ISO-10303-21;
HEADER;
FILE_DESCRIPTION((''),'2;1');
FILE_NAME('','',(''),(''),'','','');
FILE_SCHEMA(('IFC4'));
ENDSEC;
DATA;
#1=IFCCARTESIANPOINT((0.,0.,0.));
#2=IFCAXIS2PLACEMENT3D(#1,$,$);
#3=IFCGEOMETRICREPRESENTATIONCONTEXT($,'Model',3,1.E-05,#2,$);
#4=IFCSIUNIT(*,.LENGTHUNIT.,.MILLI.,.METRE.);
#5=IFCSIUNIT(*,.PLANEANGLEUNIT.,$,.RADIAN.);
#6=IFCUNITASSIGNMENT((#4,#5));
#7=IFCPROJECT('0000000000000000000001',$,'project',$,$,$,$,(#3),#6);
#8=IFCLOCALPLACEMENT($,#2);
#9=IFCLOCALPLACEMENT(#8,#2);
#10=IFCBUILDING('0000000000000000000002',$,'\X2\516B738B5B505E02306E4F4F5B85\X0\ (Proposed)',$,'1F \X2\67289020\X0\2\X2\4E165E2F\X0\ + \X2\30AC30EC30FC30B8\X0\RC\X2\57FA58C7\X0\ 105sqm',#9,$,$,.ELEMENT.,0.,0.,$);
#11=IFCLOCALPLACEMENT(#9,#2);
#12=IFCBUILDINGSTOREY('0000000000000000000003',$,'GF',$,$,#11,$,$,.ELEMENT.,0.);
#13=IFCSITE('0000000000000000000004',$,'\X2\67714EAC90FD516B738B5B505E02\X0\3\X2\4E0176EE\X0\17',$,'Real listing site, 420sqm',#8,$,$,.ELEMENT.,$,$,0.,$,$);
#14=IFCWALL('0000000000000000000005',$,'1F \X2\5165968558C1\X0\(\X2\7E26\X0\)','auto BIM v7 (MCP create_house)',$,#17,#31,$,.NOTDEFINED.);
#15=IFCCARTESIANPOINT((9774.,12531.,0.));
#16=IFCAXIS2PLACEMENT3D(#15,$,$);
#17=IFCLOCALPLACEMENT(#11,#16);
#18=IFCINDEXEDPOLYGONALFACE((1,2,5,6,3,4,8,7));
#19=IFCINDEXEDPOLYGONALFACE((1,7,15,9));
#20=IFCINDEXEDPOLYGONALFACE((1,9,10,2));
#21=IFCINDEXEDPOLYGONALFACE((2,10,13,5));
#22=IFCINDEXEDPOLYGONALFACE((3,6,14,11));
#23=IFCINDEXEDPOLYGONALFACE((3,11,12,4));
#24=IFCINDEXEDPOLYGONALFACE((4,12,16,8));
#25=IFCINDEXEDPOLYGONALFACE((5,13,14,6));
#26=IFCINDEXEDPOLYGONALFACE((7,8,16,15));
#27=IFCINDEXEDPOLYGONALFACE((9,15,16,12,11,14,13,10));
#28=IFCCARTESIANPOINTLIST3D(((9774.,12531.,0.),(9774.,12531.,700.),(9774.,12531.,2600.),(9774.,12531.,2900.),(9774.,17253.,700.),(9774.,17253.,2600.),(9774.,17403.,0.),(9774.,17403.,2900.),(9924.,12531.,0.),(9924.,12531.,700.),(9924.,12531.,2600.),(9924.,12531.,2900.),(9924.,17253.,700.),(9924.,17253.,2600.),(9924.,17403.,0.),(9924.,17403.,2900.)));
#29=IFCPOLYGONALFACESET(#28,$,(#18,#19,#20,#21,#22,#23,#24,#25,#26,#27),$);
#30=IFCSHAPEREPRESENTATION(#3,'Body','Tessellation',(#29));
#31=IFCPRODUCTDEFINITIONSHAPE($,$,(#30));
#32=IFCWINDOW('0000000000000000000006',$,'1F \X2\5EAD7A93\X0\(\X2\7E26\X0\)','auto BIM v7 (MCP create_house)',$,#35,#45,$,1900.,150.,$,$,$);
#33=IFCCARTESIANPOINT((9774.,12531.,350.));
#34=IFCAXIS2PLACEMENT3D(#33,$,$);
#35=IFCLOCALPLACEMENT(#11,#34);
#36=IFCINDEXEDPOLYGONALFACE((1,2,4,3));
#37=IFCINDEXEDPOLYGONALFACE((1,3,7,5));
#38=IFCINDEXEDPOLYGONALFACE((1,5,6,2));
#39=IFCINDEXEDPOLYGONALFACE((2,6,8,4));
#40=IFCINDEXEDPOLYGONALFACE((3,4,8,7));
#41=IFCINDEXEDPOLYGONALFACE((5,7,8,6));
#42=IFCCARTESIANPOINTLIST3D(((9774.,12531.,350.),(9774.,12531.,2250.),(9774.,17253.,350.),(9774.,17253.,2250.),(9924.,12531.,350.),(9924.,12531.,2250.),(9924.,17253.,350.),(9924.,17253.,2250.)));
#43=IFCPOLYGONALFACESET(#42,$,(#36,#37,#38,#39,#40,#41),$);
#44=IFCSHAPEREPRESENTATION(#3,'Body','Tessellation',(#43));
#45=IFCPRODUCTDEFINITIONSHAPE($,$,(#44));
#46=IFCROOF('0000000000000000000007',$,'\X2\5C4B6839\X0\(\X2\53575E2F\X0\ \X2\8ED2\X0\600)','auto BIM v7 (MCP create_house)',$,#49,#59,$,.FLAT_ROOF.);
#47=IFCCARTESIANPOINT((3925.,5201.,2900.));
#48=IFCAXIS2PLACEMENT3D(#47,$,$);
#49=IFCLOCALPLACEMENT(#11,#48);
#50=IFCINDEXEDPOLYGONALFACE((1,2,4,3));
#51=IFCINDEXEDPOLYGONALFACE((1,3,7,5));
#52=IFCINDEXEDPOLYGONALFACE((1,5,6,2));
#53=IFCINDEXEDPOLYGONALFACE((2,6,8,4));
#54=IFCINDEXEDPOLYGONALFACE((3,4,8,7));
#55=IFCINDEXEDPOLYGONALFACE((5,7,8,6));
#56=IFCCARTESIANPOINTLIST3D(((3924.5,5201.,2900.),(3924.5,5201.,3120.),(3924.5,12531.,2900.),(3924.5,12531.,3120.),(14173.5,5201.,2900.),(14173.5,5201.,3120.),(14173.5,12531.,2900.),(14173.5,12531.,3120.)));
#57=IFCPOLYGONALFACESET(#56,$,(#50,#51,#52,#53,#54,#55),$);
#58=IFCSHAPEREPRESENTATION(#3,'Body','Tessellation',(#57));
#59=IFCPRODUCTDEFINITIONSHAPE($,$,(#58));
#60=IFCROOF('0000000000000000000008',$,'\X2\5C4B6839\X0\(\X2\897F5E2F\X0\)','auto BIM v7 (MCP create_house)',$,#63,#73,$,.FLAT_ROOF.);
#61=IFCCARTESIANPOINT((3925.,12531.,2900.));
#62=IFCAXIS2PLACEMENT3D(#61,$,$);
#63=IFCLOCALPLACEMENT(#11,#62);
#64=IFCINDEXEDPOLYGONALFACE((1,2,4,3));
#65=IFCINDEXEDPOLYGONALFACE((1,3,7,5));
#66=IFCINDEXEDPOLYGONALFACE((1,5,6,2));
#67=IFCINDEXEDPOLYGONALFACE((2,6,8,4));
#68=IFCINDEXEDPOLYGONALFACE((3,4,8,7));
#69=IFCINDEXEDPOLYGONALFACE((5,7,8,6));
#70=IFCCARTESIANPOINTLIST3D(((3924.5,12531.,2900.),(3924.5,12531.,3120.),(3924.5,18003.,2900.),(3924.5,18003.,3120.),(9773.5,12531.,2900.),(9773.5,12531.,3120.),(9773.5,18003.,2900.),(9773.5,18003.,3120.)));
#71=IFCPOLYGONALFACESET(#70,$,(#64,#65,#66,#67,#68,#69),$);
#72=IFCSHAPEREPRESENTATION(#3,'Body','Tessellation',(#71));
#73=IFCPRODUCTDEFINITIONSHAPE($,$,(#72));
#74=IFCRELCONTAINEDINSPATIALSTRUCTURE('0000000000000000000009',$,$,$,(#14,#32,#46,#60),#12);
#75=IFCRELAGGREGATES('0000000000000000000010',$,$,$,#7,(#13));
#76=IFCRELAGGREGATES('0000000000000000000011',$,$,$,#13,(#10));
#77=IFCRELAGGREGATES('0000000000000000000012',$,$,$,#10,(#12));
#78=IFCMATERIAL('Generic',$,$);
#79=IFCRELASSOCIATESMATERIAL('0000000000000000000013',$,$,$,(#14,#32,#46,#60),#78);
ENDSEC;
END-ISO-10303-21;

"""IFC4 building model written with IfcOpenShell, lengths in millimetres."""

from ifc_helpers import new_model, si_unit, frame, frame_2d, origin, place, context, project, spatial, rectangle, extrude, material, element, fill, save


model = new_model("IFC4")

# Units and contexts
model_context = context("Model", 3, precision=1e-05, world=origin())
ifc_project = project(units=[si_unit("LENGTHUNIT", "METRE", prefix="MILLI"), si_unit("PLANEANGLEUNIT", "RADIAN")], contexts=[model_context])

# Site, building, storey
site_placement = place(None, origin())
site = spatial("IfcSite", under=ifc_project, at=site_placement, Name="東京都八王子市3丁目17", ObjectType="Real listing site, 420sqm", CompositionType="ELEMENT", RefElevation=0.0)
building_placement = place(site_placement, origin())
building = spatial("IfcBuilding", under=site, at=building_placement, Name="八王子市の住宅 (Proposed)", ObjectType="1F 木造2世帯 + ガレージRC基壇 105sqm", CompositionType="ELEMENT", ElevationOfRefHeight=0.0, ElevationOfTerrain=0.0)
storey_placement = place(building_placement, origin())
storey = spatial("IfcBuildingStorey", under=building, at=storey_placement, Name="GF", CompositionType="ELEMENT", Elevation=0.0)

# Shared definitions
ifc_material = material(Name="Generic")

# Wall, opening, window
wall_1_placement = place(storey_placement, frame((9774.0, 12531.0, 0.0)))
wall_1 = element("IfcWall", 1, at=wall_1_placement, inside=storey, material=ifc_material, Name="1F 入隅壁(縦)", Description="auto BIM v7 (MCP create_house)", PredefinedType="NOTDEFINED", context=model_context, shape_type="SweptSolid", body=[
    extrude(rectangle(XDim=150.0, YDim=4872.0, at=frame_2d((75.0, 2436.0))), frame((9774.0, 12531.0, 0.0)), (0.0, 0.0, 1.0), 2900.0),
])
opening_1_placement = place(storey_placement, frame((9774.0, 12531.0, 350.0)))
opening_1 = element("IfcOpeningElement", 2, at=opening_1_placement, cuts=wall_1, PredefinedType="NOTDEFINED", context=model_context, shape_type="SweptSolid", body=[
    extrude(rectangle(XDim=150.0, YDim=4722.0, at=frame_2d((75.0, 2361.0))), frame((9774.0, 12531.0, 350.0)), (0.0, 0.0, 1.0), 1900.0),
])
window_1_placement = place(storey_placement, frame((9774.0, 12531.0, 350.0)))
window_1 = element("IfcWindow", 3, at=window_1_placement, inside=storey, material=ifc_material, Name="1F 庭窓(縦)", Description="auto BIM v7 (MCP create_house)", OverallHeight=1900.0, OverallWidth=150.0, context=model_context, shape_type="SweptSolid", body=[
    extrude(rectangle(XDim=150.0, YDim=4722.0, at=frame_2d((75.0, 2361.0))), frame((9774.0, 12531.0, 350.0)), (0.0, 0.0, 1.0), 1900.0),
])
fill(opening_1, window_1)

# Roofs
roof_1_placement = place(storey_placement, frame((3925.0, 5201.0, 2900.0)))
element("IfcRoof", 4, at=roof_1_placement, inside=storey, material=ifc_material, Name="屋根(南帯 軒600)", Description="auto BIM v7 (MCP create_house)", PredefinedType="FLAT_ROOF", context=model_context, shape_type="SweptSolid", body=[
    extrude(rectangle(XDim=10249.0, YDim=7330.0, at=frame_2d((5124.0, 3665.0))), frame((3925.0, 5201.0, 2900.0)), (0.0, 0.0, 1.0), 220.0),
])
roof_2_placement = place(storey_placement, frame((3925.0, 12531.0, 2900.0)))
element("IfcRoof", 5, at=roof_2_placement, inside=storey, material=ifc_material, Name="屋根(西帯)", Description="auto BIM v7 (MCP create_house)", PredefinedType="FLAT_ROOF", context=model_context, shape_type="SweptSolid", body=[
    extrude(rectangle(XDim=5849.0, YDim=5472.0, at=frame_2d((2924.0, 2736.0))), frame((3925.0, 12531.0, 2900.0)), (0.0, 0.0, 1.0), 220.0),
])

save(model, "model.ifc")
